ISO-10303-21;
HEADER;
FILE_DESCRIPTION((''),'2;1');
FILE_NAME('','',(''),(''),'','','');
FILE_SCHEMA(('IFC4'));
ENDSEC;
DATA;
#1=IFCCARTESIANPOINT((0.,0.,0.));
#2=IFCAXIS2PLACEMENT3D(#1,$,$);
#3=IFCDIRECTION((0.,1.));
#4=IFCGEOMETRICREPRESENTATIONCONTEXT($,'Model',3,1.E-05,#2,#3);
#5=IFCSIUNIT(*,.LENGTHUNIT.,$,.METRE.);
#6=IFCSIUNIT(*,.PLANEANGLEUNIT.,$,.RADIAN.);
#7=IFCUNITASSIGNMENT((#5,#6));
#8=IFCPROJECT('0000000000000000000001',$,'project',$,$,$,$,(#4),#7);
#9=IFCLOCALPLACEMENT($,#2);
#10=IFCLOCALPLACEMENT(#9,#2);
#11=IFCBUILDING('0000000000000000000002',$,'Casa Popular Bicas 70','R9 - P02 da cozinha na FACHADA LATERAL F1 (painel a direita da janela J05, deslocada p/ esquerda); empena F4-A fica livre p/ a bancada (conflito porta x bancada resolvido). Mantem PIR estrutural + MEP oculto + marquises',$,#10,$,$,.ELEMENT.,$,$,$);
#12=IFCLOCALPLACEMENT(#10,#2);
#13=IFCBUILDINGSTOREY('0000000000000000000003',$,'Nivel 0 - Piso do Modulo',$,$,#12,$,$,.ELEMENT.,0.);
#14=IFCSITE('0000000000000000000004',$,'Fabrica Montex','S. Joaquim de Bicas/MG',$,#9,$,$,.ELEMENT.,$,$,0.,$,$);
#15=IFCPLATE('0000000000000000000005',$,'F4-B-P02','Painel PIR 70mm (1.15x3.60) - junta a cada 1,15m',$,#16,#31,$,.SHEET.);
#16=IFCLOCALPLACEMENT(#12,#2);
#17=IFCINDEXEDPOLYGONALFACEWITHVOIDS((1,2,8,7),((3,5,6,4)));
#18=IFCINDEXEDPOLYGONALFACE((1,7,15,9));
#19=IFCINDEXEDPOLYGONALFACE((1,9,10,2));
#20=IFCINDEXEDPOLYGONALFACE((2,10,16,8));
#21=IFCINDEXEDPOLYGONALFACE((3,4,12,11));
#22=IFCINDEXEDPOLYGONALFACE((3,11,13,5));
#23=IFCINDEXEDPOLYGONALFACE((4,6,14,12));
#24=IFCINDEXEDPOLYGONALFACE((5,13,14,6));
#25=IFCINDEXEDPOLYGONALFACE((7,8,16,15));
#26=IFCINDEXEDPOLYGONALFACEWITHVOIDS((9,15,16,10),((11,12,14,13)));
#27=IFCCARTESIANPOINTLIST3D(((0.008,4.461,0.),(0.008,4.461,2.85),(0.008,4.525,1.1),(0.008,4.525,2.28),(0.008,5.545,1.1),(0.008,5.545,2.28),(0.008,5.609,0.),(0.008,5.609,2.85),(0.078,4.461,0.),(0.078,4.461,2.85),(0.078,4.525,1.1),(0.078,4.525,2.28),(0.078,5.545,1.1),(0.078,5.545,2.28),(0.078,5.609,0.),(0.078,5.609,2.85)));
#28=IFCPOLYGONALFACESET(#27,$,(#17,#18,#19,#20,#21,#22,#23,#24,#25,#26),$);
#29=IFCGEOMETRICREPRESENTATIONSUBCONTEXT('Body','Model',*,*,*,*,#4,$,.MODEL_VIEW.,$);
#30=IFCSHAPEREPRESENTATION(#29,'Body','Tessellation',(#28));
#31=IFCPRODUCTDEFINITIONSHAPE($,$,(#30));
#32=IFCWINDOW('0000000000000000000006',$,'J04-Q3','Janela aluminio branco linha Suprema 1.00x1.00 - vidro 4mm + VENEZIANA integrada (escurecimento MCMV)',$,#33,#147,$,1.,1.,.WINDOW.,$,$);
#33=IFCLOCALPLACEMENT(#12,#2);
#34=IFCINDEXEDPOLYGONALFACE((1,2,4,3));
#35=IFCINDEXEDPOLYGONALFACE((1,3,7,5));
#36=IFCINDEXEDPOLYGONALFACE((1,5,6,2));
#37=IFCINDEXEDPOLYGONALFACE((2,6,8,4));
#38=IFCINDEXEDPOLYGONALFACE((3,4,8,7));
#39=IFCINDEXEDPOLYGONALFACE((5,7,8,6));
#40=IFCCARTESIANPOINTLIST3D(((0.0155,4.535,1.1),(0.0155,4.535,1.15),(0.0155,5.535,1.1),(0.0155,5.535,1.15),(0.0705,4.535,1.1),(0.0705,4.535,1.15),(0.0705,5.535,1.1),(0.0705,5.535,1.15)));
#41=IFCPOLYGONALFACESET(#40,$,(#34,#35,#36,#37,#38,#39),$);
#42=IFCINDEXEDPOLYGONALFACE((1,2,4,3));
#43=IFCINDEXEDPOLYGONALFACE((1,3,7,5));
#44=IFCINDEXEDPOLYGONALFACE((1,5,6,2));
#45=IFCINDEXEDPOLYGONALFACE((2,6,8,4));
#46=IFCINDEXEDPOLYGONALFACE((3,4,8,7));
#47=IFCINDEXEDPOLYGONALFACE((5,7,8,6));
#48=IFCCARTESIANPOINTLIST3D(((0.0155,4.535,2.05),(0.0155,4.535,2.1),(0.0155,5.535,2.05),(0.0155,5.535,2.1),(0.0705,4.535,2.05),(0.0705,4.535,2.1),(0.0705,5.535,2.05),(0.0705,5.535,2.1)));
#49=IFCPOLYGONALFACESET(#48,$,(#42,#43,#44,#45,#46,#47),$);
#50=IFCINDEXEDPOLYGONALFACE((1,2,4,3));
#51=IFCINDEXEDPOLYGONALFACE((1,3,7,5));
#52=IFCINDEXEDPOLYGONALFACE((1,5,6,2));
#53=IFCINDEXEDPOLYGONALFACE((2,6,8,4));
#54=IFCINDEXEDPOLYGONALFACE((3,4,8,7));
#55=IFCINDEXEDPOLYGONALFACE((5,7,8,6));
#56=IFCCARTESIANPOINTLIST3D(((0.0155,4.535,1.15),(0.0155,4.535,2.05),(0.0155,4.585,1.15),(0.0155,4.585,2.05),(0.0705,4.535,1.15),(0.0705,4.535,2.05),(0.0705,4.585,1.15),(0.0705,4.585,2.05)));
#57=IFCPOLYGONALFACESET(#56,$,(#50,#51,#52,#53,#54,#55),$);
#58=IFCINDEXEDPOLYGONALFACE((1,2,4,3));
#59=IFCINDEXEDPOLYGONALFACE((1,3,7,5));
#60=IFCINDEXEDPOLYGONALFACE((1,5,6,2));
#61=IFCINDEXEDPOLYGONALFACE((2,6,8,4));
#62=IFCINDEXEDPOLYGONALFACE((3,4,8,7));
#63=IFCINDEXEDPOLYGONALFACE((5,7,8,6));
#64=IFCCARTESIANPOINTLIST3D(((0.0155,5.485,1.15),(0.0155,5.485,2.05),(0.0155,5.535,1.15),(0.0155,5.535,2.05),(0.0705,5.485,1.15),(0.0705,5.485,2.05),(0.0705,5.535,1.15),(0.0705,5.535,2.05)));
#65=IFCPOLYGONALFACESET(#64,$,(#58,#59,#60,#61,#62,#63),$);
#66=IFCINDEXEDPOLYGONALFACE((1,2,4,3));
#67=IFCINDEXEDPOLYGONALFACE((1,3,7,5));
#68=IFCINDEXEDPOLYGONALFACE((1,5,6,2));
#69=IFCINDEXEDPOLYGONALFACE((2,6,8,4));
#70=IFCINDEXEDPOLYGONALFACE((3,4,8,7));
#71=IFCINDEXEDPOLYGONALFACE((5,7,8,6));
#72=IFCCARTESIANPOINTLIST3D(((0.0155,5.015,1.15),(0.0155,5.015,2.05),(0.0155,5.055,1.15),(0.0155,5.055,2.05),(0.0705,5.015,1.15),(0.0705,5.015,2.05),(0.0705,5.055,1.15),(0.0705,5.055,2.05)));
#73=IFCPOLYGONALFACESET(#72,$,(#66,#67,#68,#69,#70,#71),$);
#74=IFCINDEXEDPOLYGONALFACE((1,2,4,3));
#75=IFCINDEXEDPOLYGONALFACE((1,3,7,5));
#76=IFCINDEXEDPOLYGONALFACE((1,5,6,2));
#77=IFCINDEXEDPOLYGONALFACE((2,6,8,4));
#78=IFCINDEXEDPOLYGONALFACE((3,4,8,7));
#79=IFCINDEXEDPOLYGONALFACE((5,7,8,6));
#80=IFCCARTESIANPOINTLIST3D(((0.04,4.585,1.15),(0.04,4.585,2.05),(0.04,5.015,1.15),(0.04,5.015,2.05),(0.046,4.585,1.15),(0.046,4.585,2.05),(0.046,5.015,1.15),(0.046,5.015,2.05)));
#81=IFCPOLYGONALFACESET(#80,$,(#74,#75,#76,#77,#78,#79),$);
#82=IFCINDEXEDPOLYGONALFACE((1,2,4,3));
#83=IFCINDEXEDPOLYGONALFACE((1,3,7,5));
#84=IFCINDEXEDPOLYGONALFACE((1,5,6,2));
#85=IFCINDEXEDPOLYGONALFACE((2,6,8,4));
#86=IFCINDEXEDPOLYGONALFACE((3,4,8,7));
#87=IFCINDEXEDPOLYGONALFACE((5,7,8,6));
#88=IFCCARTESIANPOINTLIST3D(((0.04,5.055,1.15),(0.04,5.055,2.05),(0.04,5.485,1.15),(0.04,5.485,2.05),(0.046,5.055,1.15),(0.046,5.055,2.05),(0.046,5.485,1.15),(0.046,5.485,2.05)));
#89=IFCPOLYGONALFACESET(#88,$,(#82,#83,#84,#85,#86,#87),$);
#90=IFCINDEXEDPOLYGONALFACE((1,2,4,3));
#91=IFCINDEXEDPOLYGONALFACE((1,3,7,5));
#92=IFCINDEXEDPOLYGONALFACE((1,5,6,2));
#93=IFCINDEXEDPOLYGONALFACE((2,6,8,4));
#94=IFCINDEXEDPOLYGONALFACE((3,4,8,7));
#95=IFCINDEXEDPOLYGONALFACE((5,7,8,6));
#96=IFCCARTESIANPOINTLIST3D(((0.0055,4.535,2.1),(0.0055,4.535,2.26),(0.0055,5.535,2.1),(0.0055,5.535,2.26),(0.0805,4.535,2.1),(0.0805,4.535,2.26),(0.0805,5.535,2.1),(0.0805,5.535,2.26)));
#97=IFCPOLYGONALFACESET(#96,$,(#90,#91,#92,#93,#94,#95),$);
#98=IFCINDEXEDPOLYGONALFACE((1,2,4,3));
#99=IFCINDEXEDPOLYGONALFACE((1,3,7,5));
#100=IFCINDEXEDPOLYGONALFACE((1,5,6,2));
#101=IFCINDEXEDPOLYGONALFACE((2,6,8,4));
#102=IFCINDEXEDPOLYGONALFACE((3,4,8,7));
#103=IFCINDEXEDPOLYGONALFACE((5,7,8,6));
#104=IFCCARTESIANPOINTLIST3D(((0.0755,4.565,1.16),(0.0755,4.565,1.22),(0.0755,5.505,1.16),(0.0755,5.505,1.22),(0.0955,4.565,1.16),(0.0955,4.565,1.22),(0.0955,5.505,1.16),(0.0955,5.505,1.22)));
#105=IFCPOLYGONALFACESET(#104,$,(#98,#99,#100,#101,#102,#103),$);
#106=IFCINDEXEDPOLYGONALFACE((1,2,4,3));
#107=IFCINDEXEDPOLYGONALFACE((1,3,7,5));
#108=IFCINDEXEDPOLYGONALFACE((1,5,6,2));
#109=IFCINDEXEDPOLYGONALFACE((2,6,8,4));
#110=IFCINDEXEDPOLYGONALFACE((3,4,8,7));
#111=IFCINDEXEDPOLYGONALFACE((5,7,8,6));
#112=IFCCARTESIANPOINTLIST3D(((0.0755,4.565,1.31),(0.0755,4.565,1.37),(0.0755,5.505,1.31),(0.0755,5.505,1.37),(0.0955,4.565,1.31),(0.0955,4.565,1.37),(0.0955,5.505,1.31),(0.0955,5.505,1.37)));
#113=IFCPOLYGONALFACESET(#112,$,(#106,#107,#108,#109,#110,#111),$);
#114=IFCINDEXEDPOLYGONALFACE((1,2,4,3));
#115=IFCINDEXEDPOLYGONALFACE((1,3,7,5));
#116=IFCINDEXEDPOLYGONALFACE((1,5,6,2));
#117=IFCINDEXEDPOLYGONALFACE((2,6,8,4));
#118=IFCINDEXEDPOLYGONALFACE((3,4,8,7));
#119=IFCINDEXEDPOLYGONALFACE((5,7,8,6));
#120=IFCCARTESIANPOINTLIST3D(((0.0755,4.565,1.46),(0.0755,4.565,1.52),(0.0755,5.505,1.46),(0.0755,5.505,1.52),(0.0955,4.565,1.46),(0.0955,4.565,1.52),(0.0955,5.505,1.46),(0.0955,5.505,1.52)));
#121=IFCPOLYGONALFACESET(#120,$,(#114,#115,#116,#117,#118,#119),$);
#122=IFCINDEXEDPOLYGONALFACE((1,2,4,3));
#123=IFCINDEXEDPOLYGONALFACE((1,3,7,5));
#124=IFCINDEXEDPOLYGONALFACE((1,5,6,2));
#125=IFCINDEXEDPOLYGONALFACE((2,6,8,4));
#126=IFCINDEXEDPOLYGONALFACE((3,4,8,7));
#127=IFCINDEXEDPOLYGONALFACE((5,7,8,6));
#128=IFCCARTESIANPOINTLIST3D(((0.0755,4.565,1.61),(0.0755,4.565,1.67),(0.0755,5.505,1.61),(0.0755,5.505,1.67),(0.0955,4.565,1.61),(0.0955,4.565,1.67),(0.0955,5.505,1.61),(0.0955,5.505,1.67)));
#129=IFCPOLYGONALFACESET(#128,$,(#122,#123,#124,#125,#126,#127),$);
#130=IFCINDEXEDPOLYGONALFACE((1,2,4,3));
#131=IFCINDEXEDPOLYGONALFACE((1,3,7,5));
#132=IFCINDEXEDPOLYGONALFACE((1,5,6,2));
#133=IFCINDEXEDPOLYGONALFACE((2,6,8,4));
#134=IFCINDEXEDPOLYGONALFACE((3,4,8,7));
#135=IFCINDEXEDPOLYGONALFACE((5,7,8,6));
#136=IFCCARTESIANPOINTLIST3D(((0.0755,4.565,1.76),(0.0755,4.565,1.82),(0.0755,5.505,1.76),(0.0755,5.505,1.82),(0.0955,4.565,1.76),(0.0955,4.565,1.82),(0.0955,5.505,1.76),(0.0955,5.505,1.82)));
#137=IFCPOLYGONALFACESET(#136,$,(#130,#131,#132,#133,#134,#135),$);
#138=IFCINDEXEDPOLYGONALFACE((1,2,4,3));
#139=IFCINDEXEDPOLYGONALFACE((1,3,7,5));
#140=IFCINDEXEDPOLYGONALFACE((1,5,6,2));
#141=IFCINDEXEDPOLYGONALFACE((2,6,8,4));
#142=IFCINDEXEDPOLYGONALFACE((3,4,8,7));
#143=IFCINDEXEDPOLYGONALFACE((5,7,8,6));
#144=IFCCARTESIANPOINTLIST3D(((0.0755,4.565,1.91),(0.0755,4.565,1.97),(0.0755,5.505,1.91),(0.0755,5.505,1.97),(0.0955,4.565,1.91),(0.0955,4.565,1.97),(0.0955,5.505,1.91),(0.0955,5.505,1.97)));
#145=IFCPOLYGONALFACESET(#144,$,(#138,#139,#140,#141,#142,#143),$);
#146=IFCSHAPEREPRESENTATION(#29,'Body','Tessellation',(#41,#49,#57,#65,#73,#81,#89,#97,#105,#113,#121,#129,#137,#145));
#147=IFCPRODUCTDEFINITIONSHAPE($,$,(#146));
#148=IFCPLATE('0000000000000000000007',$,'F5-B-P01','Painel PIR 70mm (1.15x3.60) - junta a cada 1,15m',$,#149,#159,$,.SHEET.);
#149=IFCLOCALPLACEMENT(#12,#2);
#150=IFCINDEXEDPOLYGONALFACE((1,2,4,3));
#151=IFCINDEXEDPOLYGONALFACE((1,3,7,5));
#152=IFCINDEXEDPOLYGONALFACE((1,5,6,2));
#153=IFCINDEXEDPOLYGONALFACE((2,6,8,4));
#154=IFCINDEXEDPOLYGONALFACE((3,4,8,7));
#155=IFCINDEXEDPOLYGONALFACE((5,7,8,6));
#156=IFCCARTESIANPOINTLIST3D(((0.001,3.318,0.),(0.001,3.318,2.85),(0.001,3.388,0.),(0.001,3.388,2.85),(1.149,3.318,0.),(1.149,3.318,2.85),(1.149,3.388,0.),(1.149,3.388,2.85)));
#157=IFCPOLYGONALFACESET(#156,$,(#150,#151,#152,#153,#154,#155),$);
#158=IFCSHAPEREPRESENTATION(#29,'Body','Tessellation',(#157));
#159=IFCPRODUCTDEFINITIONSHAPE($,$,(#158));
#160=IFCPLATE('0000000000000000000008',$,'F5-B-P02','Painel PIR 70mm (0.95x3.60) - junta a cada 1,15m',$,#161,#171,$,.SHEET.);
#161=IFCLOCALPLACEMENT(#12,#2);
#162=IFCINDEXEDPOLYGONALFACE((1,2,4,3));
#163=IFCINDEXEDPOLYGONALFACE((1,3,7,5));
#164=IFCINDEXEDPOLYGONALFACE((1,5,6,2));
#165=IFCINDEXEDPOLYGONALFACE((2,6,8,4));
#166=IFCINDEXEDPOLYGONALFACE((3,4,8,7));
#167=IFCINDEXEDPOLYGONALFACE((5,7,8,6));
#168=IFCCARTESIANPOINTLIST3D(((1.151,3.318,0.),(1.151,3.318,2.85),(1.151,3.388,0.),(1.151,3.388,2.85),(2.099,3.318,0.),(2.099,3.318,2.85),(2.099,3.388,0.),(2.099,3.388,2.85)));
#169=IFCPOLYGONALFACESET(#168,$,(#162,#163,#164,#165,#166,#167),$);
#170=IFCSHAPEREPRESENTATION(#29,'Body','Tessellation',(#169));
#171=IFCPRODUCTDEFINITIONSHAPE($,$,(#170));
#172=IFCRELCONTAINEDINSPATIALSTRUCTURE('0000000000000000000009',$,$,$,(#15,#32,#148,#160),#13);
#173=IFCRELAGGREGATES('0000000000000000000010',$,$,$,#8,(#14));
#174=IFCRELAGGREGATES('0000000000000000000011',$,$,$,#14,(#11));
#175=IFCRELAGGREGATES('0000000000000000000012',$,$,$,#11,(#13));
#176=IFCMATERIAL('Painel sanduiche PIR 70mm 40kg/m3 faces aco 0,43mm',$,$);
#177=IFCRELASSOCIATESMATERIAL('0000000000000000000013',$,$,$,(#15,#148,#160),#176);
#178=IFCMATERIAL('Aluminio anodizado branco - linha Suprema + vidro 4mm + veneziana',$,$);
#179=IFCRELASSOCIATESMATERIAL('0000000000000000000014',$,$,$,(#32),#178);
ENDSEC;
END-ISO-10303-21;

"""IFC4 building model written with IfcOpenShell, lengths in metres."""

from ifc_helpers import new_model, si_unit, direction, frame, frame_2d, origin, place, context, subcontext, project, spatial, rectangle, extrude, material, element, fill, save


model = new_model("IFC4")

# Units and contexts
model_context = context("Model", 3, precision=1e-05, world=origin(), true_north=direction((0.0, 1.0)))
body_context = subcontext(model_context, "Body", "Model", "MODEL_VIEW")
ifc_project = project(units=[si_unit("LENGTHUNIT", "METRE"), si_unit("PLANEANGLEUNIT", "RADIAN")], contexts=[model_context])

# Site, building, storey
site_placement = place(None, origin())
site = spatial("IfcSite", under=ifc_project, at=site_placement, Name="Fabrica Montex", Description="S. Joaquim de Bicas/MG", CompositionType="ELEMENT", RefElevation=0.0)
building_placement = place(site_placement, origin())
building = spatial("IfcBuilding", under=site, at=building_placement, Name="Casa Popular Bicas 70", Description="R9 - P02 da cozinha na FACHADA LATERAL F1 (painel a direita da janela J05, deslocada p/ esquerda); empena F4-A fica livre p/ a bancada (conflito porta x bancada resolvido). Mantem PIR estrutural + MEP oculto + marquises", CompositionType="ELEMENT")
storey_placement = place(building_placement, origin())
storey = spatial("IfcBuildingStorey", under=building, at=storey_placement, Name="Nivel 0 - Piso do Modulo", CompositionType="ELEMENT", Elevation=0.0)

# Plate, opening, window
ifc_material_1 = material(Name="Painel sanduiche PIR 70mm 40kg/m3 faces aco 0,43mm")
plate_1_placement = place(storey_placement, frame((0.043, 4.461, 0.0), x_axis=(0.0, 1.0, 0.0)))
plate_1 = element("IfcPlate", 1, at=plate_1_placement, inside=storey, material=ifc_material_1, Name="F4-B-P02", Description="Painel PIR 70mm (1.15x3.60) - junta a cada 1,15m", PredefinedType="SHEET", context=body_context, shape_type="SweptSolid", body=[
    extrude(rectangle(XDim=1.148, YDim=0.07, at=frame_2d((0.574, 0.0))), origin(), (0.0, 0.0, 1.0), 2.85),
])
opening_1_placement = place(storey_placement, frame((0.043, 4.535, 1.1), x_axis=(0.0, 1.0, 0.0)))
opening_1 = element("IfcOpeningElement", 2, at=opening_1_placement, cuts=plate_1, PredefinedType="OPENING", context=body_context, shape_type="SweptSolid", body=[
    extrude(rectangle(XDim=1.02, YDim=0.3, at=frame_2d((0.5, 0.0))), origin(), (0.0, 0.0, 1.0), 1.18),
])
ifc_material_2 = material(Name="Aluminio anodizado branco - linha Suprema + vidro 4mm + veneziana")
window_placement = place(storey_placement, frame((0.043, 4.535, 1.1), x_axis=(0.0, 1.0, 0.0)))
window = element("IfcWindow", 3, at=window_placement, inside=storey, material=ifc_material_2, Name="J04-Q3", Description="Janela aluminio branco linha Suprema 1.00x1.00 - vidro 4mm + VENEZIANA integrada (escurecimento MCMV)", OverallHeight=1.0, OverallWidth=1.0, PredefinedType="WINDOW", context=body_context, shape_type="SweptSolid", body=[
    extrude(rectangle(XDim=1.0, YDim=0.055, at=frame_2d((0.5, 0.0))), origin(), (0.0, 0.0, 1.0), 0.05),
    extrude(rectangle(XDim=1.0, YDim=0.055, at=frame_2d((0.5, 0.0))), frame((0.0, 0.0, 0.95)), (0.0, 0.0, 1.0), 0.05),
    extrude(rectangle(XDim=0.05, YDim=0.055, at=frame_2d((0.025, 0.0))), frame((0.0, 0.0, 0.05)), (0.0, 0.0, 1.0), 0.9),
    extrude(rectangle(XDim=0.05, YDim=0.055, at=frame_2d((0.975, 0.0))), frame((0.0, 0.0, 0.05)), (0.0, 0.0, 1.0), 0.9),
    extrude(rectangle(XDim=0.04, YDim=0.055, at=frame_2d((0.5, 0.0))), frame((0.0, 0.0, 0.05)), (0.0, 0.0, 1.0), 0.9),
    extrude(rectangle(XDim=0.43, YDim=0.006, at=frame_2d((0.265, 0.0))), frame((0.0, 0.0, 0.05)), (0.0, 0.0, 1.0), 0.9),
    extrude(rectangle(XDim=0.43, YDim=0.006, at=frame_2d((0.735, 0.0))), frame((0.0, 0.0, 0.05)), (0.0, 0.0, 1.0), 0.9),
    extrude(rectangle(XDim=1.0, YDim=0.075, at=frame_2d((0.5, 0.0))), frame((0.0, 0.0, 1.0)), (0.0, 0.0, 1.0), 0.16),
    extrude(rectangle(XDim=0.94, YDim=0.02, at=frame_2d((0.5, -0.0425))), frame((0.0, 0.0, 0.06)), (0.0, 0.0, 1.0), 0.06),
    extrude(rectangle(XDim=0.94, YDim=0.02, at=frame_2d((0.5, -0.0425))), frame((0.0, 0.0, 0.21)), (0.0, 0.0, 1.0), 0.06),
    extrude(rectangle(XDim=0.94, YDim=0.02, at=frame_2d((0.5, -0.0425))), frame((0.0, 0.0, 0.36)), (0.0, 0.0, 1.0), 0.06),
    extrude(rectangle(XDim=0.94, YDim=0.02, at=frame_2d((0.5, -0.0425))), frame((0.0, 0.0, 0.51)), (0.0, 0.0, 1.0), 0.06),
    extrude(rectangle(XDim=0.94, YDim=0.02, at=frame_2d((0.5, -0.0425))), frame((0.0, 0.0, 0.66)), (0.0, 0.0, 1.0), 0.06),
    extrude(rectangle(XDim=0.94, YDim=0.02, at=frame_2d((0.5, -0.0425))), frame((0.0, 0.0, 0.81)), (0.0, 0.0, 1.0), 0.06),
])
fill(opening_1, window)

# Plates
plate_2_placement = place(storey_placement, frame((0.001, 3.353, 0.0), x_axis=(1.0, 0.0, 0.0)))
element("IfcPlate", 4, at=plate_2_placement, inside=storey, material=ifc_material_1, Name="F5-B-P01", Description="Painel PIR 70mm (1.15x3.60) - junta a cada 1,15m", PredefinedType="SHEET", context=body_context, shape_type="SweptSolid", body=[
    extrude(rectangle(XDim=1.148, YDim=0.07, at=frame_2d((0.574, 0.0))), origin(), (0.0, 0.0, 1.0), 2.85),
])
plate_3_placement = place(storey_placement, frame((1.151, 3.353, 0.0), x_axis=(1.0, 0.0, 0.0)))
element("IfcPlate", 5, at=plate_3_placement, inside=storey, material=ifc_material_1, Name="F5-B-P02", Description="Painel PIR 70mm (0.95x3.60) - junta a cada 1,15m", PredefinedType="SHEET", context=body_context, shape_type="SweptSolid", body=[
    extrude(rectangle(XDim=0.948, YDim=0.07, at=frame_2d((0.474, 0.0))), origin(), (0.0, 0.0, 1.0), 2.85),
])

save(model, "model.ifc")
